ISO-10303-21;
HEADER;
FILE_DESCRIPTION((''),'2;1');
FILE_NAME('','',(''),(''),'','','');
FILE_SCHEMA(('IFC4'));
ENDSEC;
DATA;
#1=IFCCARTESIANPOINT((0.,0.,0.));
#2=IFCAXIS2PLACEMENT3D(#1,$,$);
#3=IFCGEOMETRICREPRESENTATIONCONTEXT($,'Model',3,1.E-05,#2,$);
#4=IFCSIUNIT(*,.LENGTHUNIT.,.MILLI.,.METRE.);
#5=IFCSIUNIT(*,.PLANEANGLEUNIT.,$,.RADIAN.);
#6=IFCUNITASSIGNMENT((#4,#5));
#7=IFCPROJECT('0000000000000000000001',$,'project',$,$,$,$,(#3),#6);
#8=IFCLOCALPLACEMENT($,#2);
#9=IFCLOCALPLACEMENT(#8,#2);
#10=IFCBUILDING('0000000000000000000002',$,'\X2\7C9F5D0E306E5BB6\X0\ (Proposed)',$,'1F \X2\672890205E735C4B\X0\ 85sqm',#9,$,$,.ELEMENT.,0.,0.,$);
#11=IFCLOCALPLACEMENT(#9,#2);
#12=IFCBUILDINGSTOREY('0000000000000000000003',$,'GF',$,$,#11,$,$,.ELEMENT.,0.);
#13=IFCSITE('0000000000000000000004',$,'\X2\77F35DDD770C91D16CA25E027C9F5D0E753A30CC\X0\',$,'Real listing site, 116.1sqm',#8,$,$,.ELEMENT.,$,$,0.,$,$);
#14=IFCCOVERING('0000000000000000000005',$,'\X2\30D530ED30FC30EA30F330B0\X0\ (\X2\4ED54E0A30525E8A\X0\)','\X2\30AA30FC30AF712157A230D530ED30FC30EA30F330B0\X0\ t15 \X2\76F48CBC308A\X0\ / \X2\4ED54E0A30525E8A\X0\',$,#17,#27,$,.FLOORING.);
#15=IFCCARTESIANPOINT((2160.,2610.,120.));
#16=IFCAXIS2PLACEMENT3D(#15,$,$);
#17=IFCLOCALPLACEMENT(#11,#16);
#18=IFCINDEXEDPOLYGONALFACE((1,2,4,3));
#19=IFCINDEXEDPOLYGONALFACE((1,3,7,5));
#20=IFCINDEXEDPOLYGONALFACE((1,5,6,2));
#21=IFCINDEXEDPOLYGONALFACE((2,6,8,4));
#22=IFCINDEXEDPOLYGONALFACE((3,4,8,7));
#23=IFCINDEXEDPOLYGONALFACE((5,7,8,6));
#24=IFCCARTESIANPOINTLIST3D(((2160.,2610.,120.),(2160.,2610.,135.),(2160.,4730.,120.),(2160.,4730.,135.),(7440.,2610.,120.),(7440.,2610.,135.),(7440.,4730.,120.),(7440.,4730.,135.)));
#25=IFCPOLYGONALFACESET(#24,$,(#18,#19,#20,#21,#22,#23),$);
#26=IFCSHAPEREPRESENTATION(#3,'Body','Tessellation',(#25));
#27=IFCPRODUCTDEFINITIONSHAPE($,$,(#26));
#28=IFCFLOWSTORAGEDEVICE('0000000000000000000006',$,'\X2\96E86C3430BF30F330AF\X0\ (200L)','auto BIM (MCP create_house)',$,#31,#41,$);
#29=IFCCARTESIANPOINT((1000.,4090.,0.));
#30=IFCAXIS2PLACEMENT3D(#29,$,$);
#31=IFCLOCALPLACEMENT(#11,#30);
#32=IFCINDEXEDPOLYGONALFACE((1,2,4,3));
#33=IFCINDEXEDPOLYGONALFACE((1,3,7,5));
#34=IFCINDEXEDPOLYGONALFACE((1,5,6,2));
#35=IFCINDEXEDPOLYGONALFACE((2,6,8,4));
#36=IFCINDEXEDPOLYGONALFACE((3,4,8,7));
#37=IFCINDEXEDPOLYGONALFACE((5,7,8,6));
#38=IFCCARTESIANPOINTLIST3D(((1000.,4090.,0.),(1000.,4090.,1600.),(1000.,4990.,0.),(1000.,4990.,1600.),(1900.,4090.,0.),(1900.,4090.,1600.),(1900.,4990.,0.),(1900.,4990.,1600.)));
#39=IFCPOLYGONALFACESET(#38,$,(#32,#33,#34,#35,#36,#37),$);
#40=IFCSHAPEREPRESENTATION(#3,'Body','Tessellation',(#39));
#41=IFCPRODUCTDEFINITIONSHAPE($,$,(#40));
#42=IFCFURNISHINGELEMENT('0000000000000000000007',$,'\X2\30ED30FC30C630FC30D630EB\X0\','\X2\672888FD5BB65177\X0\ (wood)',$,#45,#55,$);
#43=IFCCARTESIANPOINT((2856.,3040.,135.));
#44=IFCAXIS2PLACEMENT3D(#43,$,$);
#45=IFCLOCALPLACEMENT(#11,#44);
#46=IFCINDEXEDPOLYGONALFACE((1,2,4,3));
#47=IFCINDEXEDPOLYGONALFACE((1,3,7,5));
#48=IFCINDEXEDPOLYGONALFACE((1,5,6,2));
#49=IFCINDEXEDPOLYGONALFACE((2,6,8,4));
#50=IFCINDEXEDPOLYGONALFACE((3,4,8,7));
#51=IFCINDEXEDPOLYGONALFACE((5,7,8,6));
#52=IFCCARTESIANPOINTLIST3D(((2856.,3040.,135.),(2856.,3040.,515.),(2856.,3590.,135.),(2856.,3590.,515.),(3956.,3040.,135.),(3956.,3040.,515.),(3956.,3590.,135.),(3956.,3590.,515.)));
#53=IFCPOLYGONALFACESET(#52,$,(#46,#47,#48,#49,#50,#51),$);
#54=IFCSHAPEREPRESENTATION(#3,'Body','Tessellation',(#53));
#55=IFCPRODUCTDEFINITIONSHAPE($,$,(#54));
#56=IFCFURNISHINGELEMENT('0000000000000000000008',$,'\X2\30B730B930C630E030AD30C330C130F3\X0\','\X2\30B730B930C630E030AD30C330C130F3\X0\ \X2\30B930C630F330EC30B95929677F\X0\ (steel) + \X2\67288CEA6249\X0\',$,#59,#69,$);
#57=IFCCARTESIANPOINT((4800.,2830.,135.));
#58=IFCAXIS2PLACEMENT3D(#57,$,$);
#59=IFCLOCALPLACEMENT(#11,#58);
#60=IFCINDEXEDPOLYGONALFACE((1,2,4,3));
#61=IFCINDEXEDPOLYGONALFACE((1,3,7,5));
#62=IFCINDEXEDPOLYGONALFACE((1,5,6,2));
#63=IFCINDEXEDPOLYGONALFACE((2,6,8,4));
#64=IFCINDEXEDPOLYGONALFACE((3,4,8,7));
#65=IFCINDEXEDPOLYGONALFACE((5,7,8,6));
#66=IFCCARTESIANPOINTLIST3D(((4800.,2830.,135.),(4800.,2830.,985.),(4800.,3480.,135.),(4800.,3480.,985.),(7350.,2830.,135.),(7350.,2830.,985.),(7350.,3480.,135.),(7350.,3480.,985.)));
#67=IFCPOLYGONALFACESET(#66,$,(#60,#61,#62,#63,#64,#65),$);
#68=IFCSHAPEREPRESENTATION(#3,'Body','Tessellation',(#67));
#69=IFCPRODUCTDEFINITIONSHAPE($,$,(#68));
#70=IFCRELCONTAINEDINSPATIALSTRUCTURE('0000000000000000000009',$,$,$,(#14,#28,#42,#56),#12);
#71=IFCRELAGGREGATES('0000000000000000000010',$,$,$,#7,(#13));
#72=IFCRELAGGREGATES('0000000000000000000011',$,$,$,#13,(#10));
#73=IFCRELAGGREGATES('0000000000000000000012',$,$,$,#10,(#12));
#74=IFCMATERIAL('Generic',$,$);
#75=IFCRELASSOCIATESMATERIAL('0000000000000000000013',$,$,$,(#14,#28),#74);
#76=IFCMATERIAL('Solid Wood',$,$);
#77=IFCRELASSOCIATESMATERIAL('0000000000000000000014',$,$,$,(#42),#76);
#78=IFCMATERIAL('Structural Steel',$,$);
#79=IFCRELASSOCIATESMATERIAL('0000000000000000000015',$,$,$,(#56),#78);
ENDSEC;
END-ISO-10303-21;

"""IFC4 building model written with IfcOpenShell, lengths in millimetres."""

from ifc_helpers import new_model, si_unit, frame, frame_2d, origin, place, context, project, spatial, rectangle, extrude, material, element, save


model = new_model("IFC4")

# Units and contexts
model_context = context("Model", 3, precision=1e-05, world=origin())
ifc_project = project(units=[si_unit("LENGTHUNIT", "METRE", prefix="MILLI"), si_unit("PLANEANGLEUNIT", "RADIAN")], contexts=[model_context])

# Site, building, storey
site_placement = place(None, origin())
site = spatial("IfcSite", under=ifc_project, at=site_placement, Name="石川県金沢市粟崎町ヌ", ObjectType="Real listing site, 116.1sqm", CompositionType="ELEMENT", RefElevation=0.0)
building_placement = place(site_placement, origin())
building = spatial("IfcBuilding", under=site, at=building_placement, Name="粟崎の家 (Proposed)", ObjectType="1F 木造平屋 85sqm", CompositionType="ELEMENT", ElevationOfRefHeight=0.0, ElevationOfTerrain=0.0)
storey_placement = place(building_placement, origin())
storey = spatial("IfcBuildingStorey", under=building, at=storey_placement, Name="GF", CompositionType="ELEMENT", Elevation=0.0)

# Shared definitions
ifc_material_1 = material(Name="Solid Wood")

# Covering
ifc_material_2 = material(Name="Generic")
covering_placement = place(storey_placement, frame((2160.0, 2610.0, 120.0)))
element("IfcCovering", 1, at=covering_placement, inside=storey, material=ifc_material_2, Name="フローリング (仕上げ床)", Description="オーク無垢フローリング t15 直貼り / 仕上げ床", PredefinedType="FLOORING", context=model_context, shape_type="SweptSolid", body=[
    extrude(rectangle(XDim=5280.0, YDim=2120.0, at=frame_2d((2640.0, 1060.0))), frame((2160.0, 2610.0, 120.0)), (0.0, 0.0, 1.0), 15.0),
])

# Flow storage device
flow_storage_device_placement = place(storey_placement, frame((1000.0, 4090.0, 0.0)))
element("IfcFlowStorageDevice", 2, at=flow_storage_device_placement, inside=storey, material=ifc_material_2, Name="雨水タンク (200L)", Description="auto BIM (MCP create_house)", context=model_context, shape_type="SweptSolid", body=[
    extrude(rectangle(XDim=900.0, YDim=900.0, at=frame_2d((450.0, 450.0))), frame((1000.0, 4090.0, 0.0)), (0.0, 0.0, 1.0), 1600.0),
])

# Furnishing elements
furnishing_1_placement = place(storey_placement, frame((2856.0, 3040.0, 135.0)))
element("IfcFurnishingElement", 3, at=furnishing_1_placement, inside=storey, material=ifc_material_1, Name="ローテーブル", Description="木製家具 (wood)", context=model_context, shape_type="SweptSolid", body=[
    extrude(rectangle(XDim=1100.0, YDim=550.0, at=frame_2d((550.0, 275.0))), frame((2856.0, 3040.0, 135.0)), (0.0, 0.0, 1.0), 380.0),
])
ifc_material_3 = material(Name="Structural Steel")
furnishing_2_placement = place(storey_placement, frame((4800.0, 2830.0, 135.0)))
element("IfcFurnishingElement", 4, at=furnishing_2_placement, inside=storey, material=ifc_material_3, Name="システムキッチン", Description="システムキッチン ステンレス天板 (steel) + 木質扉", context=model_context, shape_type="SweptSolid", body=[
    extrude(rectangle(XDim=2550.0, YDim=650.0, at=frame_2d((1275.0, 325.0))), frame((4800.0, 2830.0, 135.0)), (0.0, 0.0, 1.0), 850.0),
])

save(model, "model.ifc")
